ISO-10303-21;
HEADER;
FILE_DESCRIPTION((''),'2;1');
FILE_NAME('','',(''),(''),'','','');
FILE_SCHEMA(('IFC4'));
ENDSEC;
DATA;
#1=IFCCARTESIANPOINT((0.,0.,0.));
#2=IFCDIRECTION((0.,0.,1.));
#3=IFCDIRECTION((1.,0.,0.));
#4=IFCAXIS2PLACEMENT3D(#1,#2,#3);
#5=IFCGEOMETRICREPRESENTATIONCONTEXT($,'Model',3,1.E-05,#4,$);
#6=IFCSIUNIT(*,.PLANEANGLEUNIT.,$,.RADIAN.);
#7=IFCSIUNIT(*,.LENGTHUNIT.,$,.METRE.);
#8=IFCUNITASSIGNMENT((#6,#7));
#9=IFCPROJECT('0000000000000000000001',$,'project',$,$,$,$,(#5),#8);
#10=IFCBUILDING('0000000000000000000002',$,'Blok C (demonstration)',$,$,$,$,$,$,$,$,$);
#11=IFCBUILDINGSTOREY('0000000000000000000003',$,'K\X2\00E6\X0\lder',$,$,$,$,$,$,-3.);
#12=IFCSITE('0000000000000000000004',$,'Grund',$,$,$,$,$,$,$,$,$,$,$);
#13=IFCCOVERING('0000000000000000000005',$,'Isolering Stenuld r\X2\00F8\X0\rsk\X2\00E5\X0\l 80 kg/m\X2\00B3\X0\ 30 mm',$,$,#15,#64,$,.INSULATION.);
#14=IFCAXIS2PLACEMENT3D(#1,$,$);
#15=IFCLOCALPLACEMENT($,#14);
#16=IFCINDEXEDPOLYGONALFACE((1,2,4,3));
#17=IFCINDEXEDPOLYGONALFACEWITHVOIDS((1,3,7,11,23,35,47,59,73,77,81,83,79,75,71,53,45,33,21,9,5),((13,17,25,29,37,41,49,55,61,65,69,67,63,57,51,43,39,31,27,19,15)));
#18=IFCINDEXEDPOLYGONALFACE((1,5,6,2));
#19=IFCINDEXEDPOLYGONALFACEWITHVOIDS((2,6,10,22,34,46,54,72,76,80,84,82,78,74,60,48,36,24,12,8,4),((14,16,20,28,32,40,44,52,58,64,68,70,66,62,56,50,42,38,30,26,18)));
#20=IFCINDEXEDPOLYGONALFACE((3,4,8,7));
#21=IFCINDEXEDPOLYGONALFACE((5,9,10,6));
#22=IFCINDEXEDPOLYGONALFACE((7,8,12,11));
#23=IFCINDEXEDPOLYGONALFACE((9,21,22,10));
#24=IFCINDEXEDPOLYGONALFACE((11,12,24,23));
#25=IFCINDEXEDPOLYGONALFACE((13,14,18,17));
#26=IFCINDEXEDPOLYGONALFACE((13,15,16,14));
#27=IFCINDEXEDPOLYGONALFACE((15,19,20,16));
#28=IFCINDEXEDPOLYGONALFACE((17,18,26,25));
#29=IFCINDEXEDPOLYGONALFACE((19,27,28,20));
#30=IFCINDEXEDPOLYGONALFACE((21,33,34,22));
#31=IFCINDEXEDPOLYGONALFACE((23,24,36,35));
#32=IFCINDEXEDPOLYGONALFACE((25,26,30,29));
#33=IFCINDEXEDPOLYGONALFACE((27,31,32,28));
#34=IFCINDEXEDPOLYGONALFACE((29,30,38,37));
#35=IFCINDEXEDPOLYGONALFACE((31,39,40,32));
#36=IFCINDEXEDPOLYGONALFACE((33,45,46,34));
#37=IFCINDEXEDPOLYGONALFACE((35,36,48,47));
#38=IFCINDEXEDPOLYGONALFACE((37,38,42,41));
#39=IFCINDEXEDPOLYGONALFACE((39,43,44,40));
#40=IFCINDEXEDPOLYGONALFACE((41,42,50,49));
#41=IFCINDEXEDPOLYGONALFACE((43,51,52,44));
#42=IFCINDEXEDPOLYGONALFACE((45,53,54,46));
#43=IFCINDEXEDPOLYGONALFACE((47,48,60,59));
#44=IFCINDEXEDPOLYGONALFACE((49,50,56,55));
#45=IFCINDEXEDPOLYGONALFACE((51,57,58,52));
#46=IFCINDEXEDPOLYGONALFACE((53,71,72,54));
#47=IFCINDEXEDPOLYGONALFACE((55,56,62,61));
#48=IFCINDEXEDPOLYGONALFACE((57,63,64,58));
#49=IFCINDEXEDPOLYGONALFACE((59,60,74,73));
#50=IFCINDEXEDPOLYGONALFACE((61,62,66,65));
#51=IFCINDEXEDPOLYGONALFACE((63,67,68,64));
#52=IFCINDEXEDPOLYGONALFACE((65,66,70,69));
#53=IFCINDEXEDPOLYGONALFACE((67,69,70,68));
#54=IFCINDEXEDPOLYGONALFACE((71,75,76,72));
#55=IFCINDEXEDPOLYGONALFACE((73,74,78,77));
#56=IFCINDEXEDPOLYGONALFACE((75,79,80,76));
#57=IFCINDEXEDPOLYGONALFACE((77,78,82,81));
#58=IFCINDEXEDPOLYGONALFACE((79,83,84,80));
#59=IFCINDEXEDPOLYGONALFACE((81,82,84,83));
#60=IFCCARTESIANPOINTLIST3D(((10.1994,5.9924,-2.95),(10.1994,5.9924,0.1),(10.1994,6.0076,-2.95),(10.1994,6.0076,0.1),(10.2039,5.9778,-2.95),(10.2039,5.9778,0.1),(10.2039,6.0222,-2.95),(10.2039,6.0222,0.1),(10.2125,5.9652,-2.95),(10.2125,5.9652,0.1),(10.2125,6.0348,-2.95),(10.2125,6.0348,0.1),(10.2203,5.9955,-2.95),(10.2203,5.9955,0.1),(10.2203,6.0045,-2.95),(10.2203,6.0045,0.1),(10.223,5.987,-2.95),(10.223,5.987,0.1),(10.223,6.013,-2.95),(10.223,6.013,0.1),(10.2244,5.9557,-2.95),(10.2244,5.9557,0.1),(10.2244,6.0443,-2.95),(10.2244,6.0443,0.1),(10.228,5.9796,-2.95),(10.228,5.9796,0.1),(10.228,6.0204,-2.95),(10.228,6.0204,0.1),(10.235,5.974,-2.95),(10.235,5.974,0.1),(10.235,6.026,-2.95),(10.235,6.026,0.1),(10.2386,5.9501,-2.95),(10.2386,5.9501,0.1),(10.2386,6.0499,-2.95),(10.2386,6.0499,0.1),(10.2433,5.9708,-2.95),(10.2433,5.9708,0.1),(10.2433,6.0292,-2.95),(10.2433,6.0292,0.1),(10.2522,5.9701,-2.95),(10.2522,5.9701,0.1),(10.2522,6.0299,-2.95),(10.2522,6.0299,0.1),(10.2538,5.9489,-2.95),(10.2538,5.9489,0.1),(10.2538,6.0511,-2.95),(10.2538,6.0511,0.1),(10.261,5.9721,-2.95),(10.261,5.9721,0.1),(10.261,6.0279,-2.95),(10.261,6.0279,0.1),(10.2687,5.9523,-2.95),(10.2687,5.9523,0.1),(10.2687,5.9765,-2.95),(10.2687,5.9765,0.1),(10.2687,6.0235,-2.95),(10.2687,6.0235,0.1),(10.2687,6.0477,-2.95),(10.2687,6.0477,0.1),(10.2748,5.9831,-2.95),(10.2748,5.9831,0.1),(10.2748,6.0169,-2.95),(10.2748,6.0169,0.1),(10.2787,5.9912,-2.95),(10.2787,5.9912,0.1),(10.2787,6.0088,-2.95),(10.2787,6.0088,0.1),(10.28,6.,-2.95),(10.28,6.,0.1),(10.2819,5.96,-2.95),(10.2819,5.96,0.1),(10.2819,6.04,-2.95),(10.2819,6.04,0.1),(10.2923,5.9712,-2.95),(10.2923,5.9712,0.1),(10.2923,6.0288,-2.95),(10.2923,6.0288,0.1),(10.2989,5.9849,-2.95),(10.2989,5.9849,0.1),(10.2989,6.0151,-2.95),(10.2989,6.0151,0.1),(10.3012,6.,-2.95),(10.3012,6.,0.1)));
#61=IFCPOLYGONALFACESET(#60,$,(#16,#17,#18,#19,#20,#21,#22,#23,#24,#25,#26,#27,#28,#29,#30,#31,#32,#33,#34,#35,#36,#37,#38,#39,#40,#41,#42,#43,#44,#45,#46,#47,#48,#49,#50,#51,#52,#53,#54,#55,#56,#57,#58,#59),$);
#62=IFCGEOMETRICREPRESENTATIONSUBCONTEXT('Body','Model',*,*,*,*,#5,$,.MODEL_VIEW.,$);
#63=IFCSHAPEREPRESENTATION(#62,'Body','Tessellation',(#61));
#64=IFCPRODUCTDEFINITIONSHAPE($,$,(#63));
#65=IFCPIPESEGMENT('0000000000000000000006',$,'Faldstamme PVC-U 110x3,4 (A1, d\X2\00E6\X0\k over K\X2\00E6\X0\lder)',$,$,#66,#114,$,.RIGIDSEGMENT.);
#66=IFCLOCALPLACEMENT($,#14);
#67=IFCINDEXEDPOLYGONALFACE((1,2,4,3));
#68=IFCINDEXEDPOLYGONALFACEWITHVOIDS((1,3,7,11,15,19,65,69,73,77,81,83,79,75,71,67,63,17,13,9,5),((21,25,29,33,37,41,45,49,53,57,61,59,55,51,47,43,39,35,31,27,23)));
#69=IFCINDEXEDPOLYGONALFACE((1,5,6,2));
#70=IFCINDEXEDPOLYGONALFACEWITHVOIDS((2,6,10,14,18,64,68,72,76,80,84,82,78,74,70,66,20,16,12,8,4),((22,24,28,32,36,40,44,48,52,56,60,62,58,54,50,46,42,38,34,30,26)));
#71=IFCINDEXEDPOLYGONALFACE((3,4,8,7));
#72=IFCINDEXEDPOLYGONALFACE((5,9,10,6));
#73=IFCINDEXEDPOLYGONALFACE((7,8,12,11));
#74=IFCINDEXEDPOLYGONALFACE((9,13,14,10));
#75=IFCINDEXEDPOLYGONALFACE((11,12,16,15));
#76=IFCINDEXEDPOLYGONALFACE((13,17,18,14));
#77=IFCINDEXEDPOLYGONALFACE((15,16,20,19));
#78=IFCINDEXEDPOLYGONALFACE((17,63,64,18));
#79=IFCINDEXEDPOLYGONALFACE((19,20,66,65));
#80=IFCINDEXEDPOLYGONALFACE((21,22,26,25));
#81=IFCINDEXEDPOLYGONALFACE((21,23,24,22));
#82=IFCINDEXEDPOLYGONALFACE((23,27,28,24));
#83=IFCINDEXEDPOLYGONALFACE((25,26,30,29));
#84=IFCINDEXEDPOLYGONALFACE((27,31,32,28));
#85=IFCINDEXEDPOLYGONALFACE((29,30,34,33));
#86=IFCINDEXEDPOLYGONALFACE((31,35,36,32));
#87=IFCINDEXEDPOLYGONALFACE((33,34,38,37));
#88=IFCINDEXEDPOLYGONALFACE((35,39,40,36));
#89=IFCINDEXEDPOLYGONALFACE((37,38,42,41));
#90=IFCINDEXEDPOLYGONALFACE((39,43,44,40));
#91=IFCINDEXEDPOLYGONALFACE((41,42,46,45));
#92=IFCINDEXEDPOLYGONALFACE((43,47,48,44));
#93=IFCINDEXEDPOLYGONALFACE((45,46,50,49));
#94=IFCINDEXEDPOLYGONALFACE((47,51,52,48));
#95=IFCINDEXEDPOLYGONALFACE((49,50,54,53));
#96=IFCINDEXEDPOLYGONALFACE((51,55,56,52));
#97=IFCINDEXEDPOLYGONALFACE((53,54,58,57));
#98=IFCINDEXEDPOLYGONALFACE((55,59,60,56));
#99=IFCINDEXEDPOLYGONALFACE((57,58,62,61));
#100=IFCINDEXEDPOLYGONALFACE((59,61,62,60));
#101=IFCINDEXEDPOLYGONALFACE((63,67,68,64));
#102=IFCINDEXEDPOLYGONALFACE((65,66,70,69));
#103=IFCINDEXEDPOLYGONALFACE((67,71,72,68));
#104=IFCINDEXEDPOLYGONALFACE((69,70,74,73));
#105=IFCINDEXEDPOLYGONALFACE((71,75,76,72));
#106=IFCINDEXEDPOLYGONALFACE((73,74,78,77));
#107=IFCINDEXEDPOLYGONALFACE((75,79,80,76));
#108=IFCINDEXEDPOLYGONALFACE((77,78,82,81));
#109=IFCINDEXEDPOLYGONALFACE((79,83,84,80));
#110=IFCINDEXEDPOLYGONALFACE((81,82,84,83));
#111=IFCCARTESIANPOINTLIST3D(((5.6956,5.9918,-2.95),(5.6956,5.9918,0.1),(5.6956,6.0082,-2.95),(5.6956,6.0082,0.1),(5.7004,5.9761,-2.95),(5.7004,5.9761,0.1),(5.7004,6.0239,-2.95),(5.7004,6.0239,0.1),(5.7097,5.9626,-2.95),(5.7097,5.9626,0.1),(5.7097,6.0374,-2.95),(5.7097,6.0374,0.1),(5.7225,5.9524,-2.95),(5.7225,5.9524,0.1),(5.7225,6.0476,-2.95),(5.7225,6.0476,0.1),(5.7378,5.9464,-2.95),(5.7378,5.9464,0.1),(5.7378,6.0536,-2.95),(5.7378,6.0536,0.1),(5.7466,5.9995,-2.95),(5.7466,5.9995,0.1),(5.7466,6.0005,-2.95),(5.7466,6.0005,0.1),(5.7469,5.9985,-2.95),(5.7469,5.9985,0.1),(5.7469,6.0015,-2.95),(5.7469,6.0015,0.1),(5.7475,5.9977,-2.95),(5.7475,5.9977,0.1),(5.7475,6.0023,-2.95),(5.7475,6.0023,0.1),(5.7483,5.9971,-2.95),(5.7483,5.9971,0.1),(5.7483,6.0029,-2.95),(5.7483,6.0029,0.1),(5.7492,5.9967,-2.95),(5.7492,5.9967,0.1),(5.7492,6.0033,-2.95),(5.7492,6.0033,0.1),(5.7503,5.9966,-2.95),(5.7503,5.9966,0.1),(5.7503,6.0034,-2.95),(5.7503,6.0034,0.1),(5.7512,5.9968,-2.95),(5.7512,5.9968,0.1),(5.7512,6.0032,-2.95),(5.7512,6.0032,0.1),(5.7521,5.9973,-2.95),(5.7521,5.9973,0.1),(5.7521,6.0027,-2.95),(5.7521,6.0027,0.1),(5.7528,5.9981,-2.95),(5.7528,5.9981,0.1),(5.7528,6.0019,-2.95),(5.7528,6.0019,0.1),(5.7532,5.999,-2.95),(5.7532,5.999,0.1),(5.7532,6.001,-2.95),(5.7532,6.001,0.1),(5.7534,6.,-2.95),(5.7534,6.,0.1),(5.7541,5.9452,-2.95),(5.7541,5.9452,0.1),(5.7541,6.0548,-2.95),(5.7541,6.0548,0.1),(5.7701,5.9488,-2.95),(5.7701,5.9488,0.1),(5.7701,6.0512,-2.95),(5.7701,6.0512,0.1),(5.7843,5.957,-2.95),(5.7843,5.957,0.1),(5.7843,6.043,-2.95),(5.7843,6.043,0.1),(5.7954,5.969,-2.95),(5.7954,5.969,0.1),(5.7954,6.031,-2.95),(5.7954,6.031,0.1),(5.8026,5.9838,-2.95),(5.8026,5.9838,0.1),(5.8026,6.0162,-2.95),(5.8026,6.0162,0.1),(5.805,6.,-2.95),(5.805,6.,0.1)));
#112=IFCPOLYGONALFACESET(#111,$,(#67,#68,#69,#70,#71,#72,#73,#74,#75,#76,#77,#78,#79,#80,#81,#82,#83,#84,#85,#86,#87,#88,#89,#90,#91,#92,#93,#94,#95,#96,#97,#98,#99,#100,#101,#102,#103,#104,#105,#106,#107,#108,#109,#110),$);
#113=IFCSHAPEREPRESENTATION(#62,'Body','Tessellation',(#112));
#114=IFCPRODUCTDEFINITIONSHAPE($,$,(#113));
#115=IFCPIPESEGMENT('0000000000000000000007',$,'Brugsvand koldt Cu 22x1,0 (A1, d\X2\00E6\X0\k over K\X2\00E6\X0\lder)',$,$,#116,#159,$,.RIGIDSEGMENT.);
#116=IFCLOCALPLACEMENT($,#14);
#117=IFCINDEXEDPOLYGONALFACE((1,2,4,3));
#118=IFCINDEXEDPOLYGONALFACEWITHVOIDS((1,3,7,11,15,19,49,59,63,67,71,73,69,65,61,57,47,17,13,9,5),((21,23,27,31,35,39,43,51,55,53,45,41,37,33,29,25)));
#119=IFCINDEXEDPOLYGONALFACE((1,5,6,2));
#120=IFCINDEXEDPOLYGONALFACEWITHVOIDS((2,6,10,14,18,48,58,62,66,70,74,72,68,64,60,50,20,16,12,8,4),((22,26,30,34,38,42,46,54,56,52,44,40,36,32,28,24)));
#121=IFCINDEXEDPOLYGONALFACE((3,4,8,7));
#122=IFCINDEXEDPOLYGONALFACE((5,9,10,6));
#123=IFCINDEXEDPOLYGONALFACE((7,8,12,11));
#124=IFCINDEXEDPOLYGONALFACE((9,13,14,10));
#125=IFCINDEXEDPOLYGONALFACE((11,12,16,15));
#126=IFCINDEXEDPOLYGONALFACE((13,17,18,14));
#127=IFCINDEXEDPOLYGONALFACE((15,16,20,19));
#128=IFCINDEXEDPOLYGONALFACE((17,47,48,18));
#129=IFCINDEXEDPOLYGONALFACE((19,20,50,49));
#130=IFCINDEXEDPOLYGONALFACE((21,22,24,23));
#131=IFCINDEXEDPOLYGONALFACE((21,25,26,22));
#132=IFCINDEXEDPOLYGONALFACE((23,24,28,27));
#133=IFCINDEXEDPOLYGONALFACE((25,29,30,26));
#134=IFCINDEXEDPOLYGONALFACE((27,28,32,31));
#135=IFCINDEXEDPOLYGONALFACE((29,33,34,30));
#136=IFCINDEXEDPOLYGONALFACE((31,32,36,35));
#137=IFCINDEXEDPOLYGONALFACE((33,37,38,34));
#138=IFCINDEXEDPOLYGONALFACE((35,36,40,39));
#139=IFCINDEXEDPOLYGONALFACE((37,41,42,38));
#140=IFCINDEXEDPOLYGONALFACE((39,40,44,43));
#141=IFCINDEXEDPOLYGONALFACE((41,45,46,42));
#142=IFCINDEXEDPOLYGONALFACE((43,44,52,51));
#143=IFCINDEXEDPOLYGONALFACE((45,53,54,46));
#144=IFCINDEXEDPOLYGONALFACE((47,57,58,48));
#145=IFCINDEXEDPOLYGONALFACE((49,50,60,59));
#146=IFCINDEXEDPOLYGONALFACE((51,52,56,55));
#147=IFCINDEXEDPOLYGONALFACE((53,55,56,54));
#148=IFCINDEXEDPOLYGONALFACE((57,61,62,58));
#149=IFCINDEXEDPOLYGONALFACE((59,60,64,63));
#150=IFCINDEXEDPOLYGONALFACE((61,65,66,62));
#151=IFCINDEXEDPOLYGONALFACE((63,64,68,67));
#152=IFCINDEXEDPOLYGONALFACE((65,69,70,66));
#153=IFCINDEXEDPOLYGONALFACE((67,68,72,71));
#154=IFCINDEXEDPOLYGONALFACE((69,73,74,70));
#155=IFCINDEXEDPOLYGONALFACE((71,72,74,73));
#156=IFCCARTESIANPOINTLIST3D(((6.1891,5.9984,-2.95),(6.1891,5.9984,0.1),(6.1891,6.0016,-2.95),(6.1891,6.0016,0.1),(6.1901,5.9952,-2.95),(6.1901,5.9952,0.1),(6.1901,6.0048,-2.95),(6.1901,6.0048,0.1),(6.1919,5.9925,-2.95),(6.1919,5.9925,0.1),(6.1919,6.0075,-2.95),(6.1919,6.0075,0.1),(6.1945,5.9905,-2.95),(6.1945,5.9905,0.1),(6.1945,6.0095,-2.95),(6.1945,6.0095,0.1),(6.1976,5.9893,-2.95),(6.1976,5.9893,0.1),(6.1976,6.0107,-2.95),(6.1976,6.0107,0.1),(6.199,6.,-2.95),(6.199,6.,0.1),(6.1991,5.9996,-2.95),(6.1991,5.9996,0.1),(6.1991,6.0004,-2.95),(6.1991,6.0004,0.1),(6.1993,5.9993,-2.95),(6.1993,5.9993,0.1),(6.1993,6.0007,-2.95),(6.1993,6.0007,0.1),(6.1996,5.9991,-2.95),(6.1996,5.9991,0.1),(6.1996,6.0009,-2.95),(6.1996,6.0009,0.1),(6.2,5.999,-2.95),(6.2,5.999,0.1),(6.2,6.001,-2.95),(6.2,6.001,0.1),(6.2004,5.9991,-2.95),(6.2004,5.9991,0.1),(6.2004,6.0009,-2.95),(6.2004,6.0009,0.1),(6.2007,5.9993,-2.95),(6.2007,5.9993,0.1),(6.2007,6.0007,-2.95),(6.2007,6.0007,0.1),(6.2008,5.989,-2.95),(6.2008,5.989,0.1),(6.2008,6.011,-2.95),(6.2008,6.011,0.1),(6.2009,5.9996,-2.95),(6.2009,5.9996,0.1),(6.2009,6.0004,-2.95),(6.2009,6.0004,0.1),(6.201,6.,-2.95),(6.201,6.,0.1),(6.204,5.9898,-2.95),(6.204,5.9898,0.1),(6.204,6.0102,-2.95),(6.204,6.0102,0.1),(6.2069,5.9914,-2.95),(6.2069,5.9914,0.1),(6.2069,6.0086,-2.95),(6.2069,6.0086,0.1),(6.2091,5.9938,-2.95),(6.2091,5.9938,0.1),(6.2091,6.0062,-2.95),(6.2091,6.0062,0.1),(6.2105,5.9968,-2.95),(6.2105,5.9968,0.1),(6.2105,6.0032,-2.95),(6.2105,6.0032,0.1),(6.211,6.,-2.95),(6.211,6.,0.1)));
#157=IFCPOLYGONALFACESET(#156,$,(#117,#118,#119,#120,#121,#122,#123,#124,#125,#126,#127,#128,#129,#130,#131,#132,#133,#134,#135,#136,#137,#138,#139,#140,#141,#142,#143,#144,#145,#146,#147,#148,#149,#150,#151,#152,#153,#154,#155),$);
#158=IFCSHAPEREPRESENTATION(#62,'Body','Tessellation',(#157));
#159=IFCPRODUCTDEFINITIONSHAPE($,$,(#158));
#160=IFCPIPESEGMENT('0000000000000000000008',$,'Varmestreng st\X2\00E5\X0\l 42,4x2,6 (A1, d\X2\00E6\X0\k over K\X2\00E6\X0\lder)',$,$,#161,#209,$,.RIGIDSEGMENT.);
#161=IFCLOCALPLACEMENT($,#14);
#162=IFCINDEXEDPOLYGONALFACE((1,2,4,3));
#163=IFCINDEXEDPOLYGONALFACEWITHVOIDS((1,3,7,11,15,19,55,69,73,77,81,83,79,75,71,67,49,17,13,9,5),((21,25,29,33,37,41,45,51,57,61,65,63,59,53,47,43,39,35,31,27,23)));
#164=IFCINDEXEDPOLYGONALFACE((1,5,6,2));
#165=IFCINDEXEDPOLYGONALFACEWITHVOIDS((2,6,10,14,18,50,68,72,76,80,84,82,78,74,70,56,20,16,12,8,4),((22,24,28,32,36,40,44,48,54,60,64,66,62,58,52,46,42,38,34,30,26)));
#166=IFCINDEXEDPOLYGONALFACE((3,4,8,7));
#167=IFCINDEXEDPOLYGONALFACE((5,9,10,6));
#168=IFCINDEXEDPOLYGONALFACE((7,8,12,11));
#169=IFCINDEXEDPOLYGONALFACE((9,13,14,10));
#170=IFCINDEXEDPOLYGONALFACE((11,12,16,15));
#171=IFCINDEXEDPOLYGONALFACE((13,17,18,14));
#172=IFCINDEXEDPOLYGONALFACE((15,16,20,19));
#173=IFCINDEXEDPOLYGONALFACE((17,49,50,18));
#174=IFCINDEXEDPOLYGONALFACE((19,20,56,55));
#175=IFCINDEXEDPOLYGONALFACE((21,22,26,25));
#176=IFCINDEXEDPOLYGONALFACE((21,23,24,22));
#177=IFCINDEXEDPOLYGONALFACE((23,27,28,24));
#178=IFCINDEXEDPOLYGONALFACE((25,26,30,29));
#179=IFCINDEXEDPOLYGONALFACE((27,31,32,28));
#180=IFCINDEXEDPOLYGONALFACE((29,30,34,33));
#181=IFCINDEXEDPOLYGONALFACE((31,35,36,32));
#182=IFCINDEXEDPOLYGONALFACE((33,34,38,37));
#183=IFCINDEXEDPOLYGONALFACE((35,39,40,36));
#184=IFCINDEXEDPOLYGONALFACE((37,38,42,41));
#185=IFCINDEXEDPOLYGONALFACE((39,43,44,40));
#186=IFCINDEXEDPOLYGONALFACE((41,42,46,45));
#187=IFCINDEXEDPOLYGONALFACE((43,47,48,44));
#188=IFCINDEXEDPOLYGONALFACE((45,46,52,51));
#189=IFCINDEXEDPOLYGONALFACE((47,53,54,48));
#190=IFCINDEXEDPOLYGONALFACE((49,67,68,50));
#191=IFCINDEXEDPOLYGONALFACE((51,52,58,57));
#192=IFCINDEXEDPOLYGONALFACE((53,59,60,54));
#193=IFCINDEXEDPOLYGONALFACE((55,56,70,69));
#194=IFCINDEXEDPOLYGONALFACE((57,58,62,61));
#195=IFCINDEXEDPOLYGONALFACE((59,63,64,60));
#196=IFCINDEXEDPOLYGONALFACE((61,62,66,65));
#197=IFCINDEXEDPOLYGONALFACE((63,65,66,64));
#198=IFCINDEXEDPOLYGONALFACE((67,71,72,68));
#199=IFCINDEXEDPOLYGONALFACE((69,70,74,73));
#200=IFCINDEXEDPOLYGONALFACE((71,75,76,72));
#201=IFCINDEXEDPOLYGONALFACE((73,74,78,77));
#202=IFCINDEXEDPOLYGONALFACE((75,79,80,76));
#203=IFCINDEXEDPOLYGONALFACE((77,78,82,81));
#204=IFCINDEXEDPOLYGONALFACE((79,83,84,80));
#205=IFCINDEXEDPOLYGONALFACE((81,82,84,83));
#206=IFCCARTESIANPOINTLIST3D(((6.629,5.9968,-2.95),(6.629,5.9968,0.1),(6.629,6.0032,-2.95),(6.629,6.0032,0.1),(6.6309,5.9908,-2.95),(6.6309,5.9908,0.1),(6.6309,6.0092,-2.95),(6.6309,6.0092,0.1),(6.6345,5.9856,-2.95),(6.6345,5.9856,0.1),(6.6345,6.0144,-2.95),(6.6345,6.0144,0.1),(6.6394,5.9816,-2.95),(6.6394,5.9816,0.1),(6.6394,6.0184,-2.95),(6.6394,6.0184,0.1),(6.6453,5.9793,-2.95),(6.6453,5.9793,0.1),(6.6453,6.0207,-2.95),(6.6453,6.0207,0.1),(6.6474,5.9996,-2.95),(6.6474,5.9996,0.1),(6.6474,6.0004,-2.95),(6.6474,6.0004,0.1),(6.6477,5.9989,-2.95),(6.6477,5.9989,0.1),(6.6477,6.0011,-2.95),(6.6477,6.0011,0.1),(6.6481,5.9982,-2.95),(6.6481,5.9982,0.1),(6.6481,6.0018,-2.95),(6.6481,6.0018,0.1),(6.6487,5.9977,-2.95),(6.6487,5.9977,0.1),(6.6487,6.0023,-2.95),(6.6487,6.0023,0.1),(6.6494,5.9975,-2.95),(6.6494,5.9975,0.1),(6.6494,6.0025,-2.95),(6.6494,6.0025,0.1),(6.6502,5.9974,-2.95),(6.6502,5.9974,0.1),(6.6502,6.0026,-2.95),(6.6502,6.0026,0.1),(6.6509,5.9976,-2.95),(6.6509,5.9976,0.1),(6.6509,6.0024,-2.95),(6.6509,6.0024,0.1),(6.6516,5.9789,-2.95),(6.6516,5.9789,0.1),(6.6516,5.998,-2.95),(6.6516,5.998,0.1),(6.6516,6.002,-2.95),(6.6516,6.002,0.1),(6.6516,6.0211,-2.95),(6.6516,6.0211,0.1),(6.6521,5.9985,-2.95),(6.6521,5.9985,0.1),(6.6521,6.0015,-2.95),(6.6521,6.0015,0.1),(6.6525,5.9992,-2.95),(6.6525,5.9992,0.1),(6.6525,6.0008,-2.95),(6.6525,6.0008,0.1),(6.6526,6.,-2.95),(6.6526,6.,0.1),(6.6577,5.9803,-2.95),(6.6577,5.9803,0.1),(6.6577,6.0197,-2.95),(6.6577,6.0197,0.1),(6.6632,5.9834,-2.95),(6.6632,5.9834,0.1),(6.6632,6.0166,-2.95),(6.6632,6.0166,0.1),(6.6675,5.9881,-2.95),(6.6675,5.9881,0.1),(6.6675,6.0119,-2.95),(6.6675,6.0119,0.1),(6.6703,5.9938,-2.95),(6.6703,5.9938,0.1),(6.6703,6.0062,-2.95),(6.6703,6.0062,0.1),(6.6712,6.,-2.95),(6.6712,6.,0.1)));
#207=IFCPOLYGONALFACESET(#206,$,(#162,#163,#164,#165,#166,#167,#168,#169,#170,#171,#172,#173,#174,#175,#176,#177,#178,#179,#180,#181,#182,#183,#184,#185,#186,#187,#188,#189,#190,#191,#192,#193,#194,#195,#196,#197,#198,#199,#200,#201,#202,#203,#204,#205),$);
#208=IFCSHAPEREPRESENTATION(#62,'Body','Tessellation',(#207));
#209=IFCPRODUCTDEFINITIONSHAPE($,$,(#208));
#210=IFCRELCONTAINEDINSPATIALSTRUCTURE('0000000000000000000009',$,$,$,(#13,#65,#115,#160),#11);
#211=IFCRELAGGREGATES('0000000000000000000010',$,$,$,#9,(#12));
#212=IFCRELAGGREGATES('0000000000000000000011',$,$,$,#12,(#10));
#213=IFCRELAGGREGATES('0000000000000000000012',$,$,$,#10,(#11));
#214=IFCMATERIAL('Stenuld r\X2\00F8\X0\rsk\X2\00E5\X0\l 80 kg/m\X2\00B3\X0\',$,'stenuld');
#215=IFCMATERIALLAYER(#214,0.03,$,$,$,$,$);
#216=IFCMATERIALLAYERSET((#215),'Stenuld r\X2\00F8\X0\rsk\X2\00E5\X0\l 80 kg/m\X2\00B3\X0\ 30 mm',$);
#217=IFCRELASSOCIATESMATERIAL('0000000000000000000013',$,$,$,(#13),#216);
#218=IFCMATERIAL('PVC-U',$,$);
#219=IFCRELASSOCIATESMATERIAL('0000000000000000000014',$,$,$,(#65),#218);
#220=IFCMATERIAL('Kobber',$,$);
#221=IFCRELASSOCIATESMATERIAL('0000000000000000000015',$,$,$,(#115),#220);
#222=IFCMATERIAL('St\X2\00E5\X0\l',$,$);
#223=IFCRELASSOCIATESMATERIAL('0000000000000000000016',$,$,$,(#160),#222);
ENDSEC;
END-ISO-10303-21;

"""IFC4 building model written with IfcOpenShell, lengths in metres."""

from ifc_helpers import new_model, si_unit, frame, origin_with_axes, place, context, subcontext, project, spatial, hollow_circle, extrude, material, layer, layer_set, element, save


model = new_model("IFC4")

# Units and contexts
model_context = context("Model", 3, precision=1e-05, world=origin_with_axes())
body_context = subcontext(model_context, "Body", "Model", "MODEL_VIEW")
ifc_project = project(units=[si_unit("PLANEANGLEUNIT", "RADIAN"), si_unit("LENGTHUNIT", "METRE")], contexts=[model_context])

# Site, building, storey
site = spatial("IfcSite", under=ifc_project, Name="Grund")
building = spatial("IfcBuilding", under=site, Name="Blok C (demonstration)")
storey = spatial("IfcBuildingStorey", under=building, Name="Kælder", Elevation=-3.0)

# Covering
ifc_material_1 = material(Name="Stenuld rørskål 80 kg/m³", Category="stenuld")
ifc_layer_1 = layer(ifc_material_1, 0.03)
ifc_layer_set_1 = layer_set([ifc_layer_1], Name="Stenuld rørskål 80 kg/m³ 30 mm")
covering_1_placement = place(None, origin_with_axes())
element("IfcCovering", 1, at=covering_1_placement, inside=storey, material=ifc_layer_set_1, Name="Isolering Stenuld rørskål 80 kg/m³ 30 mm", PredefinedType="INSULATION", context=body_context, shape_type="SweptSolid", body=[
    extrude(hollow_circle(Radius=0.0512, WallThickness=0.0212), frame((10.25, 6.0, -2.95), z_axis=(0.0, 0.0, 1.0), x_axis=(1.0, 0.0, 0.0)), (0.0, 0.0, 1.0), 3.05),
])

# Pipe segments
ifc_material_2 = material(Name="PVC-U")
pipe_segment_1_placement = place(None, origin_with_axes())
element("IfcPipeSegment", 2, at=pipe_segment_1_placement, inside=storey, material=ifc_material_2, Name="Faldstamme PVC-U 110x3,4 (A1, dæk over Kælder)", PredefinedType="RIGIDSEGMENT", context=body_context, shape_type="SweptSolid", body=[
    extrude(hollow_circle(Radius=0.055, WallThickness=0.0516), frame((5.75, 6.0, -2.95), z_axis=(0.0, 0.0, 1.0), x_axis=(1.0, 0.0, 0.0)), (0.0, 0.0, 1.0), 3.05),
])
ifc_material_3 = material(Name="Kobber")
pipe_segment_2_placement = place(None, origin_with_axes())
element("IfcPipeSegment", 3, at=pipe_segment_2_placement, inside=storey, material=ifc_material_3, Name="Brugsvand koldt Cu 22x1,0 (A1, dæk over Kælder)", PredefinedType="RIGIDSEGMENT", context=body_context, shape_type="SweptSolid", body=[
    extrude(hollow_circle(Radius=0.011, WallThickness=0.01), frame((6.2, 6.0, -2.95), z_axis=(0.0, 0.0, 1.0), x_axis=(1.0, 0.0, 0.0)), (0.0, 0.0, 1.0), 3.05),
])
ifc_material_4 = material(Name="Stål")
pipe_segment_3_placement = place(None, origin_with_axes())
element("IfcPipeSegment", 4, at=pipe_segment_3_placement, inside=storey, material=ifc_material_4, Name="Varmestreng stål 42,4x2,6 (A1, dæk over Kælder)", PredefinedType="RIGIDSEGMENT", context=body_context, shape_type="SweptSolid", body=[
    extrude(hollow_circle(Radius=0.0212, WallThickness=0.0186), frame((6.65, 6.0, -2.95), z_axis=(0.0, 0.0, 1.0), x_axis=(1.0, 0.0, 0.0)), (0.0, 0.0, 1.0), 3.05),
])

save(model, "model.ifc")
